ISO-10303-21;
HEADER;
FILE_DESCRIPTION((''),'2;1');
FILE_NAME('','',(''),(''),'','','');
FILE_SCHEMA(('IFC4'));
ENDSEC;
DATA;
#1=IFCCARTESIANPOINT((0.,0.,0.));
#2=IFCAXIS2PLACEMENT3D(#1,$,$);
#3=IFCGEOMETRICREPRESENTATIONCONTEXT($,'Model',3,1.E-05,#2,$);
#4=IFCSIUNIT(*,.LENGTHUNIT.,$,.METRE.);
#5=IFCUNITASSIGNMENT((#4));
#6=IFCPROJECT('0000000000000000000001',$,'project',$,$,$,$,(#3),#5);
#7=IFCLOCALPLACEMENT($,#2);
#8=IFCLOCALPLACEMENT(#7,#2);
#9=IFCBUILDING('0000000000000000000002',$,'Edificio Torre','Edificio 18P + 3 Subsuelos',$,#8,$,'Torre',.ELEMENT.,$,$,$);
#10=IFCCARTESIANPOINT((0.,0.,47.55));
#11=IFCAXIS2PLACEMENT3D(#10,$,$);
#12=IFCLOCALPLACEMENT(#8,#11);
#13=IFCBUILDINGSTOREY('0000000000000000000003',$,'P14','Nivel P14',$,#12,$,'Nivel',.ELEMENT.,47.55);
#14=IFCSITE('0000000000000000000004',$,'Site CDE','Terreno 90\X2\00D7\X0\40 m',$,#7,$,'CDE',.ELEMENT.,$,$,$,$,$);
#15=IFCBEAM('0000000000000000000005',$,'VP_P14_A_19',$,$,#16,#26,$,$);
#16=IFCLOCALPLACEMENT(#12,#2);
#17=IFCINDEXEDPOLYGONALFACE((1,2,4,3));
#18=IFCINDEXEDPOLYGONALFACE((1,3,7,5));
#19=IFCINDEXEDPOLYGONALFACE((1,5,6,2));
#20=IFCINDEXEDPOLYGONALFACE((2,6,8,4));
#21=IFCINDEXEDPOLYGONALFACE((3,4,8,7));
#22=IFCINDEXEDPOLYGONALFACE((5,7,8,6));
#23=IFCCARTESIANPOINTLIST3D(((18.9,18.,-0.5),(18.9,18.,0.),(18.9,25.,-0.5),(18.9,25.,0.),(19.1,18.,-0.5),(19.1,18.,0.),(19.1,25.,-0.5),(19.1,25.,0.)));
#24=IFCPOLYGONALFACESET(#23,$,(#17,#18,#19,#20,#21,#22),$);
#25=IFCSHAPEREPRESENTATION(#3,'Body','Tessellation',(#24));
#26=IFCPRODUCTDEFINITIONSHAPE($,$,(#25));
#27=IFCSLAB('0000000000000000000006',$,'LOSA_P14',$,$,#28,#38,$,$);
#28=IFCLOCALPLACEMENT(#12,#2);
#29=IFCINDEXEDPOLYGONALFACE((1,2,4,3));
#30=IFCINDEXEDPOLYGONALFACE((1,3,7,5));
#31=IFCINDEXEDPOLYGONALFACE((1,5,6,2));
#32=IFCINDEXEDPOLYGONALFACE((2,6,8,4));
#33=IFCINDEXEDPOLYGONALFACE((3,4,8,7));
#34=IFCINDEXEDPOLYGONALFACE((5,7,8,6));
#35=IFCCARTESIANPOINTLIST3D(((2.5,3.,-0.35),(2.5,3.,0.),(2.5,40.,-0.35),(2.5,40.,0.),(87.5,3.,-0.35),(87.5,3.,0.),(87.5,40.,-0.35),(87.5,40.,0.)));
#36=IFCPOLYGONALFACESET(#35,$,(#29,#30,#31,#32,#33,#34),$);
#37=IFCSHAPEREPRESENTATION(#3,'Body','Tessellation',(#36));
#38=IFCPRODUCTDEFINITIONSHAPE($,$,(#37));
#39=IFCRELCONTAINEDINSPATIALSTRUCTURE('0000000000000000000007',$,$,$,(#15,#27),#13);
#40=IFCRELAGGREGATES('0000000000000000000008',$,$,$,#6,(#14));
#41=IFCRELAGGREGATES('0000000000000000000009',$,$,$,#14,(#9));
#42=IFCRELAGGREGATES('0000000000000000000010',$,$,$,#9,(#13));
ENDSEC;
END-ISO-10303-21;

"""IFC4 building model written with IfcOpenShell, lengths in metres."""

from ifc_helpers import new_model, si_unit, frame, origin, origin_2d, place, context, project, spatial, rectangle, extrude, element, save


model = new_model("IFC4")

# Units and contexts
model_context = context("Model", 3, precision=1e-05, world=origin())
ifc_project = project(units=[si_unit("LENGTHUNIT", "METRE")], contexts=[model_context])

# Site, building, storey
site_placement = place(None, origin())
site = spatial("IfcSite", under=ifc_project, at=site_placement, Name="Site CDE", Description="Terreno 90×40 m", LongName="CDE", CompositionType="ELEMENT")
building_placement = place(site_placement, origin())
building = spatial("IfcBuilding", under=site, at=building_placement, Name="Edificio Torre", Description="Edificio 18P + 3 Subsuelos", LongName="Torre", CompositionType="ELEMENT")
storey_placement = place(building_placement, frame((0.0, 0.0, 47.55)))
storey = spatial("IfcBuildingStorey", under=building, at=storey_placement, Name="P14", Description="Nivel P14", LongName="Nivel", CompositionType="ELEMENT", Elevation=47.55)

# Beam
beam_1_placement = place(storey_placement, frame((19.0, 21.5, -0.5)))
element("IfcBeam", 1, at=beam_1_placement, inside=storey, Name="VP_P14_A_19", context=model_context, shape_type="SweptSolid", body=[
    extrude(rectangle(XDim=0.2, YDim=7.0, at=origin_2d()), origin(), (0.0, 0.0, 1.0), 0.5),
])

# Slab
slab_placement = place(storey_placement, frame((45.0, 21.5, -0.35)))
element("IfcSlab", 2, at=slab_placement, inside=storey, Name="LOSA_P14", context=model_context, shape_type="SweptSolid", body=[
    extrude(rectangle(XDim=85.0, YDim=37.0, at=origin_2d()), origin(), (0.0, 0.0, 1.0), 0.35),
])

save(model, "model.ifc")
